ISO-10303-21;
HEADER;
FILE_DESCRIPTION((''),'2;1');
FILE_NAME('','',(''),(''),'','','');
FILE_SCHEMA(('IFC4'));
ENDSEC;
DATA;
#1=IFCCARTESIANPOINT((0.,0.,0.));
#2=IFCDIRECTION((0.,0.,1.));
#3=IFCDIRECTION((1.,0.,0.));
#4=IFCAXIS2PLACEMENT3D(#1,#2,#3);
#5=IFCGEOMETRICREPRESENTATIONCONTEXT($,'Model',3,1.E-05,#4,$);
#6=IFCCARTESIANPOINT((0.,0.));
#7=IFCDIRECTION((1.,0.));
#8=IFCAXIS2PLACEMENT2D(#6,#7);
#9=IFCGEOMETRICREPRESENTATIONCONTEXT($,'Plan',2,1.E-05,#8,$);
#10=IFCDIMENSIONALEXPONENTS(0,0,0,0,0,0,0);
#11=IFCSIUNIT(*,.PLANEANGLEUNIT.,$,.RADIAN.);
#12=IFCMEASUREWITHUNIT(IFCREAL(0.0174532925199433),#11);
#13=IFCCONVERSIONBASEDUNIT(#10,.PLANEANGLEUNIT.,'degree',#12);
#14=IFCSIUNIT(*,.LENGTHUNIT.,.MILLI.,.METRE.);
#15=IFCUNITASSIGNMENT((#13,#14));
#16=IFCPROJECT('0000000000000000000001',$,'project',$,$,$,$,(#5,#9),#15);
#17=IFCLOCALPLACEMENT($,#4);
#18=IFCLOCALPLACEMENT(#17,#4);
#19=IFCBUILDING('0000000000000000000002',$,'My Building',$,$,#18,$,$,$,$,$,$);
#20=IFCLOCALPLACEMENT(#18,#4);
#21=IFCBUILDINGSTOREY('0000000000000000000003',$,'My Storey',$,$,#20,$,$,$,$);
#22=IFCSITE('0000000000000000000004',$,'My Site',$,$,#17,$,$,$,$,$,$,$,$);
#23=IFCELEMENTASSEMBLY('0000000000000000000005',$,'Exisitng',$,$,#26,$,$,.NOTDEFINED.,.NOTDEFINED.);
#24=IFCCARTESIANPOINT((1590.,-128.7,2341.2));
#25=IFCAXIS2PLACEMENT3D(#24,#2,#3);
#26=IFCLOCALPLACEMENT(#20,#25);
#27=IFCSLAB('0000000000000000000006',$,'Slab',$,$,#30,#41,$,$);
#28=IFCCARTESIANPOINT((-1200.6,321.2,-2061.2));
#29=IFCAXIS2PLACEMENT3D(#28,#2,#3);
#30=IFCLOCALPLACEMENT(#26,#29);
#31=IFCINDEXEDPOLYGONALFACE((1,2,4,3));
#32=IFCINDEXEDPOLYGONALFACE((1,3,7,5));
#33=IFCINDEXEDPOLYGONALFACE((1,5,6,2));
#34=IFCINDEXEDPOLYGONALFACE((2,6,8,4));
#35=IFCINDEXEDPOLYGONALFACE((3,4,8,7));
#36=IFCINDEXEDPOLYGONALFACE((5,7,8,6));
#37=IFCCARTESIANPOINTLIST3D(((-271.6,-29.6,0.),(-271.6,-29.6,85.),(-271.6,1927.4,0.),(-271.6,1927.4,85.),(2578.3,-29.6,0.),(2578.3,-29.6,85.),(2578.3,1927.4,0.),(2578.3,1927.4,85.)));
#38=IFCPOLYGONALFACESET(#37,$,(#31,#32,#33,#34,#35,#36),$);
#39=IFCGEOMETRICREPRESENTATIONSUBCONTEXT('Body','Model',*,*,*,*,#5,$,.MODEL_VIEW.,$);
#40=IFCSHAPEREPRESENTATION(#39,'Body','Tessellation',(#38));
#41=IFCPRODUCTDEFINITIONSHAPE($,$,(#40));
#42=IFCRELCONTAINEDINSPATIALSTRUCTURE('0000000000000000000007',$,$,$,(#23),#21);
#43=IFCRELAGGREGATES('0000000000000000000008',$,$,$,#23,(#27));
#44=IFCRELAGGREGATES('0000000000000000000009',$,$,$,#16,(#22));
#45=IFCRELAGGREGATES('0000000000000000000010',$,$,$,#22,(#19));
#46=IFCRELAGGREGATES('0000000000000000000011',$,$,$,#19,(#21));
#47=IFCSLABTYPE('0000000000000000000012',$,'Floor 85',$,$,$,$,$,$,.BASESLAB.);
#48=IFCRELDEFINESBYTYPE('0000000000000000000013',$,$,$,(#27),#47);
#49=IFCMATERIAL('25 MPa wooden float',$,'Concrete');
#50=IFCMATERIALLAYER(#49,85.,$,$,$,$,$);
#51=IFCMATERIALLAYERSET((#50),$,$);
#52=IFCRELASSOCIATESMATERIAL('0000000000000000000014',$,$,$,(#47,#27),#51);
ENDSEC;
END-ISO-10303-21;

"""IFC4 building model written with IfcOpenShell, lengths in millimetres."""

from ifc_helpers import new_model, entity, si_unit, converted_unit, frame, origin_with_axes, origin_2d_with_axis, place, context, subcontext, project, spatial, line, indexed_curve, outline, extrude, material, layer, layer_set, layer_usage, type_object, element, aggregate, save


model = new_model("IFC4")

# Units and contexts
model_context = context("Model", 3, precision=1e-05, world=origin_with_axes())
plan_context = context("Plan", 2, precision=1e-05, world=origin_2d_with_axis())
body_context = subcontext(model_context, "Body", "Model", "MODEL_VIEW")
ifc_project = project(units=[converted_unit("PLANEANGLEUNIT", "degree", entity("IfcReal", 0.0174532925199433), si_unit("PLANEANGLEUNIT", "RADIAN"), dimensions=[0, 0, 0, 0, 0, 0, 0]), si_unit("LENGTHUNIT", "METRE", prefix="MILLI")], contexts=[model_context, plan_context])

# Site, building, storey
site_placement = place(None, origin_with_axes())
site = spatial("IfcSite", under=ifc_project, at=site_placement, Name="My Site")
building_placement = place(site_placement, origin_with_axes())
building = spatial("IfcBuilding", under=site, at=building_placement, Name="My Building")
storey_placement = place(building_placement, origin_with_axes())
storey = spatial("IfcBuildingStorey", under=building, at=storey_placement, Name="My Storey")

# Element assembly
assembly_1_placement = place(storey_placement, frame((1590.0, -128.7, 2341.2), z_axis=(0.0, 0.0, 1.0), x_axis=(1.0, 0.0, 0.0)))
assembly_1 = element("IfcElementAssembly", 1, at=assembly_1_placement, inside=storey, Name="Exisitng", AssemblyPlace="NOTDEFINED", PredefinedType="NOTDEFINED")

# Slab
ifc_material_1 = material(Name="25 MPa wooden float", Category="Concrete")
ifc_layer_1 = layer(ifc_material_1, 85.0)
ifc_layer_set_1 = layer_set([ifc_layer_1])
ifc_layer_usage_1 = layer_usage(ifc_layer_set_1, "AXIS3", "POSITIVE", 0.0)
slab_type = type_object("IfcSlabType", Name="Floor 85", PredefinedType="BASESLAB", material=ifc_layer_set_1)
slab_placement = place(assembly_1_placement, frame((-1200.6, 321.2, -2061.2), z_axis=(0.0, 0.0, 1.0), x_axis=(1.0, 0.0, 0.0)))
slab = element("IfcSlab", 2, at=slab_placement, type_object=slab_type, material=ifc_layer_usage_1, Name="Slab", context=body_context, shape_type="SweptSolid", body=[
    extrude(outline(indexed_curve([(2578.3, 1927.4), (2578.3, -29.6), (-271.6, -29.6), (-271.6, 1927.4)], segments=[line(4, 1), line(1, 2), line(2, 3), line(3, 4)], self_intersect=False)), None, (0.0, 0.0, 1.0), 85.0),
])

aggregate(assembly_1, [slab])

save(model, "model.ifc")
